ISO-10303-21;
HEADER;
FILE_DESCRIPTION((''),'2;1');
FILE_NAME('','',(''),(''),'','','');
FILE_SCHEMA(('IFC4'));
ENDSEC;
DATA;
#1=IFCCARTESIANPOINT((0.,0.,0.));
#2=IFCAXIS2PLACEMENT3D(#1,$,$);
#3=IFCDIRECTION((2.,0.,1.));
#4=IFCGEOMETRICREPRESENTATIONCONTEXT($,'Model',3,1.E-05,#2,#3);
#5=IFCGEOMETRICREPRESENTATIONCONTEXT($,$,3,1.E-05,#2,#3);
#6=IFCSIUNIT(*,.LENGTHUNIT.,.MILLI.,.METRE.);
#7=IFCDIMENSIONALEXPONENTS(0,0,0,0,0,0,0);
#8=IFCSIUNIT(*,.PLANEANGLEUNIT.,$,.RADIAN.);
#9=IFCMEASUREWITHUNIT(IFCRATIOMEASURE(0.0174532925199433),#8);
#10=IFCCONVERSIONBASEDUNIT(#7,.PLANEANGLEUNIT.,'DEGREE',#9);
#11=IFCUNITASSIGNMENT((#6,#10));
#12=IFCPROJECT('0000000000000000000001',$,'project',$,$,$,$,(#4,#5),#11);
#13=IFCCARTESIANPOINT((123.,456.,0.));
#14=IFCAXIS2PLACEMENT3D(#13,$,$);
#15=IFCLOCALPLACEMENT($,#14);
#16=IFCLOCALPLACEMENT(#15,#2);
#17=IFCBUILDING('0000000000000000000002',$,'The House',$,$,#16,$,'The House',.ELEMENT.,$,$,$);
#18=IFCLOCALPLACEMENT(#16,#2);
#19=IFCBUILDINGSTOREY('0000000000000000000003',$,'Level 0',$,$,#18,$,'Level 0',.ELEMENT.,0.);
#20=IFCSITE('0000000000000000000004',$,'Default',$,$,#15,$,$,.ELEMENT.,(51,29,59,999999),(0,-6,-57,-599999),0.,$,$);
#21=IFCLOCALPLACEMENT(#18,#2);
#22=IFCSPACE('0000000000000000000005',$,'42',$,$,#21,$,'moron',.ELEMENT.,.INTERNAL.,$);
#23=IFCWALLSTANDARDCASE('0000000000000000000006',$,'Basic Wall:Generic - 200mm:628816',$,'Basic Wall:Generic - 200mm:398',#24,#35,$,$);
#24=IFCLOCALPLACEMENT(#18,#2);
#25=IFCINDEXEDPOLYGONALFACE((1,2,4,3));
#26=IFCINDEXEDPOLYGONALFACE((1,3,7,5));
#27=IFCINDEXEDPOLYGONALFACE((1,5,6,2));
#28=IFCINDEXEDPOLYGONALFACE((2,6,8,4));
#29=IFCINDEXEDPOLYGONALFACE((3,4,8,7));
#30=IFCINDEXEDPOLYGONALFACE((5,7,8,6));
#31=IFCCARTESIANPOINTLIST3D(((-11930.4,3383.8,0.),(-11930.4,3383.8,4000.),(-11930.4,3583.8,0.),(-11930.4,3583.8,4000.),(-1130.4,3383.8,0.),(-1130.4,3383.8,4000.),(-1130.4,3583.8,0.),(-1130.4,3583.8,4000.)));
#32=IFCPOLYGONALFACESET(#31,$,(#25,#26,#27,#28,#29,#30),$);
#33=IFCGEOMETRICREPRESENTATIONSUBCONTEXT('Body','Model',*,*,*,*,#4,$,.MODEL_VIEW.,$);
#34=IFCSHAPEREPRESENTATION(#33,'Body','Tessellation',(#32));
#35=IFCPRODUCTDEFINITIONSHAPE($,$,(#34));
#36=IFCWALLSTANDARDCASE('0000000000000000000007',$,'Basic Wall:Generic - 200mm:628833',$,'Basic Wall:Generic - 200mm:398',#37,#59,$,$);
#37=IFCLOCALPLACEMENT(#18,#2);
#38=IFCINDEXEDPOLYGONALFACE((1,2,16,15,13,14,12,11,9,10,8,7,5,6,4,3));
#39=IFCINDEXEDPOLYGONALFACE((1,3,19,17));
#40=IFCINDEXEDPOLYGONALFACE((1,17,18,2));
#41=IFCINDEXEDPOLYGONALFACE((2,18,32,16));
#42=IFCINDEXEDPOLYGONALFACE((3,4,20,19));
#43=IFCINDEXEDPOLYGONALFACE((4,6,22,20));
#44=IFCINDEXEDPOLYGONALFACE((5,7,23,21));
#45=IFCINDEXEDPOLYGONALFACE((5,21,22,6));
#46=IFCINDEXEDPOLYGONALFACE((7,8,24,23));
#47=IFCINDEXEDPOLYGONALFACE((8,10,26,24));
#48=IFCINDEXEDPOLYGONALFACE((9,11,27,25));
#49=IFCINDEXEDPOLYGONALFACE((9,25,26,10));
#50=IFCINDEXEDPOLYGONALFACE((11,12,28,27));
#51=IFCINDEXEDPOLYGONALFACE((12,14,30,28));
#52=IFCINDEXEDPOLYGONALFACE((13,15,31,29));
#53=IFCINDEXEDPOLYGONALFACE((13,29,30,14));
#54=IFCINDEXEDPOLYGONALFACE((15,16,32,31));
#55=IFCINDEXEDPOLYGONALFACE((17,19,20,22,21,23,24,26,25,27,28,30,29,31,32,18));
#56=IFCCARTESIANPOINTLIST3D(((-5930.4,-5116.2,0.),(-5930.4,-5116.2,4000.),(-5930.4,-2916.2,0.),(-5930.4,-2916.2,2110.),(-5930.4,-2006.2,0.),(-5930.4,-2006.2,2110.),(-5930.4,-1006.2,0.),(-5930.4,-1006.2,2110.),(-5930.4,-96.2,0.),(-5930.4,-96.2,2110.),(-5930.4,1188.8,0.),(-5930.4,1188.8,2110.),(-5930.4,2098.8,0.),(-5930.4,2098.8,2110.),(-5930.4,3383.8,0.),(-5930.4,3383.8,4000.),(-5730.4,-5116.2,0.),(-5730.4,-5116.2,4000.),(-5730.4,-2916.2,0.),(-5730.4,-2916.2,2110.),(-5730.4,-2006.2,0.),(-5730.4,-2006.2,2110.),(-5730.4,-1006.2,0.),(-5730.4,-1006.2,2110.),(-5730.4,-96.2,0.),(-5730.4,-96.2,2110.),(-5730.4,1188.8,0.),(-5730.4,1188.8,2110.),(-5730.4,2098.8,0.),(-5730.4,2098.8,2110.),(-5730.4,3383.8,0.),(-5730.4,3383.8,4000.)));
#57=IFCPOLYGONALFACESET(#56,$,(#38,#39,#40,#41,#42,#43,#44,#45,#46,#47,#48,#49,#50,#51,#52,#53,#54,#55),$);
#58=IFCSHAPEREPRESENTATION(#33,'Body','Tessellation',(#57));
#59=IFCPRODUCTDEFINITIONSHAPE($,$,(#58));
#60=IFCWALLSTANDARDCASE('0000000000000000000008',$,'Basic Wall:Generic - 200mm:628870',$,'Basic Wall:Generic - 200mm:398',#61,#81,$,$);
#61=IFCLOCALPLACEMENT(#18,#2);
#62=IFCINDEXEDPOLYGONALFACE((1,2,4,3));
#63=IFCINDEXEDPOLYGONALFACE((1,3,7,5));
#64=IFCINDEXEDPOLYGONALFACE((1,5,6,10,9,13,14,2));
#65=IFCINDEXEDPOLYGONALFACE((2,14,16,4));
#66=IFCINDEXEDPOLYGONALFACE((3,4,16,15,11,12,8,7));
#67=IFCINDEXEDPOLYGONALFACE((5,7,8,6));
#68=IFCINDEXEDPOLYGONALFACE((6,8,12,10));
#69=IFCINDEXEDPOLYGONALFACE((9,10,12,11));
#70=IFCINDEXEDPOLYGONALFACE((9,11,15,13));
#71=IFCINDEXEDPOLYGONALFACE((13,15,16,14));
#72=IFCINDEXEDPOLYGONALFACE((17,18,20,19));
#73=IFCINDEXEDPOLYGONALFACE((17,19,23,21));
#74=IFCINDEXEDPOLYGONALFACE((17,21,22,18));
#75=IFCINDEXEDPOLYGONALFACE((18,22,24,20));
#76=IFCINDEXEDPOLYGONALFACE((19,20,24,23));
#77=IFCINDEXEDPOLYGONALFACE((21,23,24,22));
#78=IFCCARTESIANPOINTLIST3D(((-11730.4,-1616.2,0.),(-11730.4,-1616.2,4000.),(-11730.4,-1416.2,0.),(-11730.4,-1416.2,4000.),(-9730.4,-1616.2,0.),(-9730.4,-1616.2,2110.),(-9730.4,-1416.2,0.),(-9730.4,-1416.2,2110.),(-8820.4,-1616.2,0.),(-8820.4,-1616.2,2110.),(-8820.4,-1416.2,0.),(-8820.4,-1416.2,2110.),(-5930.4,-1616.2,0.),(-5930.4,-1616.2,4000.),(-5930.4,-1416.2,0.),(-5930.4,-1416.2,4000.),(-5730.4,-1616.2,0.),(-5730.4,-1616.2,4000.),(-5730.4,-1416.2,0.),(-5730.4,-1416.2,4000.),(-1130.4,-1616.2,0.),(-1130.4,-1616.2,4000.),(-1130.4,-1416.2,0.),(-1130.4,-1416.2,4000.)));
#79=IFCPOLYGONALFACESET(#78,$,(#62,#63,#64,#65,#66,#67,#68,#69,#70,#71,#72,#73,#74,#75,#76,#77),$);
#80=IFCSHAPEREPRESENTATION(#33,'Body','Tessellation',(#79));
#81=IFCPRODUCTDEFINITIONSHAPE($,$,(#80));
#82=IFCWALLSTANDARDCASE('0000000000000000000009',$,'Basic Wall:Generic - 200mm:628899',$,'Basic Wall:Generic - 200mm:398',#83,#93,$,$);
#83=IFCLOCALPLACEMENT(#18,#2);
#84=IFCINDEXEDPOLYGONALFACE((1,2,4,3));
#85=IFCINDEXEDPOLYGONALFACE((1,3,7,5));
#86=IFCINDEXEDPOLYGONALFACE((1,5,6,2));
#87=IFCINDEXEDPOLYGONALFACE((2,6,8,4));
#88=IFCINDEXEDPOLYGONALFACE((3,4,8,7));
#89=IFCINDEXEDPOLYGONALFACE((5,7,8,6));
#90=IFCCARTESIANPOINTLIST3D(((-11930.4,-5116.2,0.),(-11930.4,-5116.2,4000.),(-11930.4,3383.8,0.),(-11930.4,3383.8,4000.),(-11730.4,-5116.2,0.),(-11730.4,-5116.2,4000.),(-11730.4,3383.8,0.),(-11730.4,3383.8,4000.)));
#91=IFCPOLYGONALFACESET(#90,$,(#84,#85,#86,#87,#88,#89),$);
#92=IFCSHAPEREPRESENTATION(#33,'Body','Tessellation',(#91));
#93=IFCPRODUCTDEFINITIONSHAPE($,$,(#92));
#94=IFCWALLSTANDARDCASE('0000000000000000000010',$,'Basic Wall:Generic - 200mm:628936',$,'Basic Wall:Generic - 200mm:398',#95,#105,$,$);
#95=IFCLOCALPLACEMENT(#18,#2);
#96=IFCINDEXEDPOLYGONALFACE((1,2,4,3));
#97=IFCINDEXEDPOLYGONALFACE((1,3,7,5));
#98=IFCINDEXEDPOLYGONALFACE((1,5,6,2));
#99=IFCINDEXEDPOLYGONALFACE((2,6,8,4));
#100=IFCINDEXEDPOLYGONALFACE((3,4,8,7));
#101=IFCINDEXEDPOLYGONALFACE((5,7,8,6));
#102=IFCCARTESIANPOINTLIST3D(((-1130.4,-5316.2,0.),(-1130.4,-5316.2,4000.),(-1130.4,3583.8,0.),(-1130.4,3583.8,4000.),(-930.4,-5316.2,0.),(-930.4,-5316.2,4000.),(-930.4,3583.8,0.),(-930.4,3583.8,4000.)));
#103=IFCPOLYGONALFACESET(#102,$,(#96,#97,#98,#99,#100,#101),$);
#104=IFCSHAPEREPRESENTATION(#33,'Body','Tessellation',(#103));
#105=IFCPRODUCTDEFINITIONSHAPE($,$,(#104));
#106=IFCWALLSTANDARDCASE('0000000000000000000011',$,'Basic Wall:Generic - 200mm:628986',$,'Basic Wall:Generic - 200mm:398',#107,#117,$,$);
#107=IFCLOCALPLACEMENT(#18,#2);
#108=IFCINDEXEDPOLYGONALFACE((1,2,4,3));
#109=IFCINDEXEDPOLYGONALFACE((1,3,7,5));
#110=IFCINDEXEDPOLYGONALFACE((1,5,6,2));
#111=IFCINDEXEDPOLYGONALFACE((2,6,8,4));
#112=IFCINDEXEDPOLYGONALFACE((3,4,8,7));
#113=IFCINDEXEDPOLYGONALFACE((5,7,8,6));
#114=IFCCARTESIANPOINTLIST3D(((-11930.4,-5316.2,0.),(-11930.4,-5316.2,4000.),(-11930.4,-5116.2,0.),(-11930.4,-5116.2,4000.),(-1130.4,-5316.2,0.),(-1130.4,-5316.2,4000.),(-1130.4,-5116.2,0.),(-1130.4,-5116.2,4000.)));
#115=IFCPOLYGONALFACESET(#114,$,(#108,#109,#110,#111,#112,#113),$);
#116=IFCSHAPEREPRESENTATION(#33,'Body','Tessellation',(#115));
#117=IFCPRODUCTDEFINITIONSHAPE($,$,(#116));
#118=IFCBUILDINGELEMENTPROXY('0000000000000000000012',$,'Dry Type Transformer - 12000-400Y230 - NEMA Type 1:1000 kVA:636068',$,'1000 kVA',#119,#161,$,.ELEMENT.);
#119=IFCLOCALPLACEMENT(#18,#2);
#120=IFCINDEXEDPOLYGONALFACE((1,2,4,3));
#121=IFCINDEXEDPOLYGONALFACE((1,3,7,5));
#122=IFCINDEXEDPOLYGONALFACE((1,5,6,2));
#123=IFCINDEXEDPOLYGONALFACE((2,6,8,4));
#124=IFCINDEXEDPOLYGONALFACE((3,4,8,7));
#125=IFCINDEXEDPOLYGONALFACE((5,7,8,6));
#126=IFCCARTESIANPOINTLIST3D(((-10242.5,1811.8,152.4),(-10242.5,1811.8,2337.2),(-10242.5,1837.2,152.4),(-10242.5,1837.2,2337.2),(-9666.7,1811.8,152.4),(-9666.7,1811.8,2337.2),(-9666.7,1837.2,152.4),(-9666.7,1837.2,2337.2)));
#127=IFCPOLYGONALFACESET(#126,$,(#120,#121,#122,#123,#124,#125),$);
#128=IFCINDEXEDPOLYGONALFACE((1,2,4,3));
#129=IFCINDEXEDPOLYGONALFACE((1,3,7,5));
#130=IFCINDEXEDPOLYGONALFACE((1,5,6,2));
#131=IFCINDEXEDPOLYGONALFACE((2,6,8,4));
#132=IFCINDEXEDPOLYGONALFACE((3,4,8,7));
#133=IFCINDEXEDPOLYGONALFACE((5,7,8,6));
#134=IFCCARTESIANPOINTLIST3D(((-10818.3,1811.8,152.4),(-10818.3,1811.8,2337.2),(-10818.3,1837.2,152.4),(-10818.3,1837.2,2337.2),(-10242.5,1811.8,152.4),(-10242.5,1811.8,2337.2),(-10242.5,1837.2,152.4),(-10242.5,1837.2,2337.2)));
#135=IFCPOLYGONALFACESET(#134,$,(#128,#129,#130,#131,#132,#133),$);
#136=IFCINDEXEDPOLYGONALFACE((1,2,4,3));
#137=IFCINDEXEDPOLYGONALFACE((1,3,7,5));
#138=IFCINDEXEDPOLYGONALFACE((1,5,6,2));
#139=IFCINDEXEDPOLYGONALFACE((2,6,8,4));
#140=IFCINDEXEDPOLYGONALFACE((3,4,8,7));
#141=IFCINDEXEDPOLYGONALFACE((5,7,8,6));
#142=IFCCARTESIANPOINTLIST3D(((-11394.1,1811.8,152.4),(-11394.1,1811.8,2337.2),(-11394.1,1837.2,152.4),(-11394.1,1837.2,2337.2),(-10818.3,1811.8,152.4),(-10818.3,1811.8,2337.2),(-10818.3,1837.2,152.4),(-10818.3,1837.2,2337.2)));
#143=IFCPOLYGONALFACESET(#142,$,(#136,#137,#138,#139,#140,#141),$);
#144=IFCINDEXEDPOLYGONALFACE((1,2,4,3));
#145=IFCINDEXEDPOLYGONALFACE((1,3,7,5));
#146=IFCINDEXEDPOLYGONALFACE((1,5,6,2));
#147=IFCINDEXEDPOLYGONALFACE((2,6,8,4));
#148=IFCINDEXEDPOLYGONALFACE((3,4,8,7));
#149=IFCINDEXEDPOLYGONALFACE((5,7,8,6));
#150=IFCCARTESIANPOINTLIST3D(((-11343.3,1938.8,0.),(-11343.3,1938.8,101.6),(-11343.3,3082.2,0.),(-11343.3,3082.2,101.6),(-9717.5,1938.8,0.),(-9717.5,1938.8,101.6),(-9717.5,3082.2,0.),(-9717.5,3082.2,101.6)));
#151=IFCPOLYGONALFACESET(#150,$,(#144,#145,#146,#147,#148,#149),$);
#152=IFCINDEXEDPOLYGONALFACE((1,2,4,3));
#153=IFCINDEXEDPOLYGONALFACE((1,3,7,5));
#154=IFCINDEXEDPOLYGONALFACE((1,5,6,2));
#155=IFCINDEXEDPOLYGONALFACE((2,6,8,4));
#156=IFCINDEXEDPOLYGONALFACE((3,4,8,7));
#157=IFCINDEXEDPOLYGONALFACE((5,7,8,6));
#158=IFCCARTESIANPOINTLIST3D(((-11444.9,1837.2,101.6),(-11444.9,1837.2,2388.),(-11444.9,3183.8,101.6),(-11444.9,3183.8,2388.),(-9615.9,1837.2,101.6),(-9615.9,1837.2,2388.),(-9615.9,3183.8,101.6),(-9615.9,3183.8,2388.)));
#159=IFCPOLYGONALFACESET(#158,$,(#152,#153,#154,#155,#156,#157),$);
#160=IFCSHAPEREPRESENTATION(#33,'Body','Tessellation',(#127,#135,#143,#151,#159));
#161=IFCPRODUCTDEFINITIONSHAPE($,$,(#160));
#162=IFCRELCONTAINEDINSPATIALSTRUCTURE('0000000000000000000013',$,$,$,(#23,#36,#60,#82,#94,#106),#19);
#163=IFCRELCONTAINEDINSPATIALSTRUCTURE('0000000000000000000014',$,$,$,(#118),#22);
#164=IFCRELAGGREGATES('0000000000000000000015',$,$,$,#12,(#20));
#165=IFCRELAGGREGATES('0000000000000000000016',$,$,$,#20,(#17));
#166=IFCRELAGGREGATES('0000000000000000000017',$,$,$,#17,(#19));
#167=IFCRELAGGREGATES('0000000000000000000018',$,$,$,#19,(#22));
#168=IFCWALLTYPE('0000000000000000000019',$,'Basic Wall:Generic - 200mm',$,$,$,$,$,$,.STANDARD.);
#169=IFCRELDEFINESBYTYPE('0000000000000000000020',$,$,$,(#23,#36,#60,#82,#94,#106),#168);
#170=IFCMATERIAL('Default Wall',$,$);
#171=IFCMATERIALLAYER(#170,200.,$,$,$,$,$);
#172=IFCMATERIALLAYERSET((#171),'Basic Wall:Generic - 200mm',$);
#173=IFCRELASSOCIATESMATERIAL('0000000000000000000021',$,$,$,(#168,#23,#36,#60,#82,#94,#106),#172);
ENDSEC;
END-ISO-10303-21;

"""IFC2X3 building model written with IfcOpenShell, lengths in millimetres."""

from ifc_helpers import new_model, entity, si_unit, converted_unit, direction, frame, frame_2d, origin, origin_2d_with_axis, place, context, subcontext, project, spatial, rectangle, extrude, source, transform, mapped, material, layer, layer_set, layer_usage, type_object, element, save


model = new_model("IFC2X3")

# Units and contexts
model_context = context("Model", 3, precision=1e-05, world=origin(), true_north=direction((2.0, 0.0, 1.0)))
context_of_model = context(None, 3, precision=1e-05, world=origin(), true_north=direction((2.0, 0.0, 1.0)))
body_context = subcontext(model_context, "Body", "Model", "MODEL_VIEW")
ifc_project = project(units=[si_unit("LENGTHUNIT", "METRE", prefix="MILLI"), converted_unit("PLANEANGLEUNIT", "DEGREE", entity("IfcRatioMeasure", 0.0174532925199433), si_unit("PLANEANGLEUNIT", "RADIAN"), dimensions=[0, 0, 0, 0, 0, 0, 0])], contexts=[model_context, context_of_model])

# Site, building, storey
site_placement = place(None, frame((123.0, 456.0, 0.0)))
site = spatial("IfcSite", under=ifc_project, at=site_placement, Name="Default", CompositionType="ELEMENT", RefLatitude=(51, 29, 59, 999999), RefLongitude=(0, -6, -57, -599999), RefElevation=0.0)
building_placement = place(site_placement, origin())
building = spatial("IfcBuilding", under=site, at=building_placement, Name="The House", LongName="The House", CompositionType="ELEMENT")
storey_placement = place(building_placement, origin())
storey = spatial("IfcBuildingStorey", under=building, at=storey_placement, Name="Level 0", LongName="Level 0", CompositionType="ELEMENT", Elevation=0.0)

# Wall
ifc_material = material(Name="Default Wall")
ifc_layer = layer(ifc_material, 200.0)
ifc_layer_set = layer_set([ifc_layer], Name="Basic Wall:Generic - 200mm")
ifc_layer_usage_1 = layer_usage(ifc_layer_set, "AXIS2", "NEGATIVE", 100.0)
wall_type = type_object("IfcWallType", Name="Basic Wall:Generic - 200mm", PredefinedType="STANDARD", material=ifc_layer_set)
wall_1_placement = place(storey_placement, frame((-11930.4, 3483.8, 0.0)))
element("IfcWallStandardCase", 1, at=wall_1_placement, inside=storey, type_object=wall_type, material=ifc_layer_usage_1, Name="Basic Wall:Generic - 200mm:628816", ObjectType="Basic Wall:Generic - 200mm:398", context=body_context, shape_type="SweptSolid", body=[
    extrude(rectangle(XDim=10800.0, YDim=200.0, at=frame_2d((5400.0, 0.0), x_axis=(-1.0, 0.0))), origin(), (0.0, 0.0, 1.0), 4000.0),
])

# Walls, openings
ifc_layer_usage_2 = layer_usage(ifc_layer_set, "AXIS2", "NEGATIVE", 100.0)
wall_2_placement = place(storey_placement, frame((-5830.4, 3383.8, 0.0), z_axis=(0.0, 0.0, 1.0), x_axis=(0.0, -1.0, 0.0)))
wall_2 = element("IfcWallStandardCase", 2, at=wall_2_placement, inside=storey, type_object=wall_type, material=ifc_layer_usage_2, Name="Basic Wall:Generic - 200mm:628833", ObjectType="Basic Wall:Generic - 200mm:398", context=body_context, shape_type="SweptSolid", body=[
    extrude(rectangle(XDim=8500.0, YDim=200.0, at=frame_2d((4250.0, 0.0), x_axis=(-1.0, 0.0))), origin(), (0.0, 0.0, 1.0), 4000.0),
])
opening_1_placement = place(wall_2_placement, frame((6300.0, 100.0, 0.0)))
element("IfcOpeningElement", 3, at=opening_1_placement, cuts=wall_2, ObjectType="Opening", context=body_context, shape_type="SweptSolid", body=[
    extrude(rectangle(XDim=2110.0, YDim=910.0, at=frame_2d((1055.0, 455.0), x_axis=(1.0, 0.0))), frame((0.0, 0.0, 0.0), z_axis=(0.0, -1.0, 0.0), x_axis=(0.0, 0.0, 1.0)), (0.0, 0.0, 1.0), 200.0),
])
opening_2_placement = place(wall_2_placement, frame((3480.0, -100.0, 0.0)))
element("IfcOpeningElement", 4, at=opening_2_placement, cuts=wall_2, ObjectType="Opening", context=body_context, shape_type="SweptSolid", body=[
    extrude(rectangle(XDim=2110.0, YDim=910.0, at=frame_2d((1055.0, 455.0), x_axis=(1.0, 0.0))), frame((0.0, 0.0, 0.0), z_axis=(0.0, 1.0, 0.0), x_axis=(0.0, 0.0, 1.0)), (0.0, 0.0, 1.0), 200.0),
])
opening_3_placement = place(wall_2_placement, frame((2195.0, 100.0, 0.0)))
element("IfcOpeningElement", 5, at=opening_3_placement, cuts=wall_2, ObjectType="Opening", context=body_context, shape_type="SweptSolid", body=[
    extrude(rectangle(XDim=2110.0, YDim=910.0, at=frame_2d((1055.0, 455.0), x_axis=(1.0, 0.0))), frame((0.0, 0.0, 0.0), z_axis=(0.0, -1.0, 0.0), x_axis=(0.0, 0.0, 1.0)), (0.0, 0.0, 1.0), 200.0),
])
ifc_layer_usage_3 = layer_usage(ifc_layer_set, "AXIS2", "NEGATIVE", 100.0)
wall_3_placement = place(storey_placement, frame((-1130.4, -1516.2, 0.0), z_axis=(0.0, 0.0, 1.0), x_axis=(-1.0, 0.0, 0.0)))
wall_3 = element("IfcWallStandardCase", 6, at=wall_3_placement, inside=storey, type_object=wall_type, material=ifc_layer_usage_3, Name="Basic Wall:Generic - 200mm:628870", ObjectType="Basic Wall:Generic - 200mm:398", context=body_context, shape_type="SweptSolid", body=[
    extrude(rectangle(XDim=10600.0, YDim=200.0, at=frame_2d((5300.0, 0.0), x_axis=(-1.0, 0.0))), origin(), (0.0, 0.0, 1.0), 4000.0),
])
opening_4_placement = place(storey_placement, frame((-1130.4, -1516.2, 0.0), z_axis=(0.0, 0.0, 1.0), x_axis=(-1.0, 0.0, 0.0)))
element("IfcOpeningElement", 7, at=opening_4_placement, cuts=wall_3, ObjectType="Opening", context=body_context, shape_type="SweptSolid", body=[
    extrude(rectangle(XDim=4000.0, YDim=200.0, at=origin_2d_with_axis()), frame((4800.0, 0.0, 2000.0), z_axis=(-1.0, 0.0, 0.0), x_axis=(0.0, 0.0, 1.0)), (0.0, 0.0, 1.0), 200.0),
])
opening_5_placement = place(wall_3_placement, frame((8600.0, 100.0, 0.0)))
element("IfcOpeningElement", 8, at=opening_5_placement, cuts=wall_3, ObjectType="Opening", context=body_context, shape_type="SweptSolid", body=[
    extrude(rectangle(XDim=2110.0, YDim=910.0, at=frame_2d((1055.0, 455.0), x_axis=(1.0, 0.0))), frame((0.0, 0.0, 0.0), z_axis=(0.0, -1.0, 0.0), x_axis=(0.0, 0.0, 1.0)), (0.0, 0.0, 1.0), 200.0),
])

# Walls
ifc_layer_usage_4 = layer_usage(ifc_layer_set, "AXIS2", "NEGATIVE", 100.0)
wall_4_placement = place(storey_placement, frame((-11830.4, -5116.2, 0.0), z_axis=(0.0, 0.0, 1.0), x_axis=(0.0, 1.0, 0.0)))
element("IfcWallStandardCase", 9, at=wall_4_placement, inside=storey, type_object=wall_type, material=ifc_layer_usage_4, Name="Basic Wall:Generic - 200mm:628899", ObjectType="Basic Wall:Generic - 200mm:398", context=body_context, shape_type="SweptSolid", body=[
    extrude(rectangle(XDim=8500.0, YDim=200.0, at=frame_2d((4250.0, 0.0), x_axis=(-1.0, 0.0))), origin(), (0.0, 0.0, 1.0), 4000.0),
])
ifc_layer_usage_5 = layer_usage(ifc_layer_set, "AXIS2", "NEGATIVE", 100.0)
wall_5_placement = place(storey_placement, frame((-1030.4, 3583.8, 0.0), z_axis=(0.0, 0.0, 1.0), x_axis=(0.0, -1.0, 0.0)))
element("IfcWallStandardCase", 10, at=wall_5_placement, inside=storey, type_object=wall_type, material=ifc_layer_usage_5, Name="Basic Wall:Generic - 200mm:628936", ObjectType="Basic Wall:Generic - 200mm:398", context=body_context, shape_type="SweptSolid", body=[
    extrude(rectangle(XDim=8900.0, YDim=200.0, at=frame_2d((4450.0, 0.0), x_axis=(-1.0, 0.0))), origin(), (0.0, 0.0, 1.0), 4000.0),
])
ifc_layer_usage_6 = layer_usage(ifc_layer_set, "AXIS2", "NEGATIVE", 100.0)
wall_6_placement = place(storey_placement, frame((-1130.4, -5216.2, 0.0), z_axis=(0.0, 0.0, 1.0), x_axis=(-1.0, 0.0, 0.0)))
element("IfcWallStandardCase", 11, at=wall_6_placement, inside=storey, type_object=wall_type, material=ifc_layer_usage_6, Name="Basic Wall:Generic - 200mm:628986", ObjectType="Basic Wall:Generic - 200mm:398", context=body_context, shape_type="SweptSolid", body=[
    extrude(rectangle(XDim=10800.0, YDim=200.0, at=frame_2d((5400.0, 0.0), x_axis=(-1.0, 0.0))), origin(), (0.0, 0.0, 1.0), 4000.0),
])

# Shared definitions
space_1_placement = place(storey_placement, origin())
space_1 = spatial("IfcSpace", under=storey, at=space_1_placement, Name="42", LongName="moron", CompositionType="ELEMENT", InteriorOrExteriorSpace="INTERNAL")

# Building element proxy
shared_shape = source(origin(), body_context, "Body", "SweptSolid", [
    extrude(rectangle(XDim=575.8, YDim=25.4, at=frame_2d((0.0, 0.0), x_axis=(1.0, 0.0))), frame((575.8, -1359.3, 152.4), z_axis=(0.0, 0.0, 1.0), x_axis=(-1.0, 0.0, 0.0)), (0.0, 0.0, 1.0), 2184.8),
    extrude(rectangle(XDim=575.8, YDim=25.4, at=origin_2d_with_axis()), frame((0.0, -1359.3, 152.4), z_axis=(0.0, 0.0, 1.0), x_axis=(-1.0, 0.0, 0.0)), (0.0, 0.0, 1.0), 2184.8),
    extrude(rectangle(XDim=575.8, YDim=25.4, at=origin_2d_with_axis()), frame((-575.8, -1359.3, 152.4), z_axis=(0.0, 0.0, 1.0), x_axis=(-1.0, 0.0, 0.0)), (0.0, 0.0, 1.0), 2184.8),
    extrude(rectangle(XDim=1625.8, YDim=1143.4, at=frame_2d((0.0, 0.0), x_axis=(1.0, 0.0))), frame((0.0, -673.3, 0.0), z_axis=(0.0, 0.0, 1.0), x_axis=(-1.0, 0.0, 0.0)), (0.0, 0.0, 1.0), 101.6),
    extrude(rectangle(XDim=1829.0, YDim=1346.6, at=origin_2d_with_axis()), frame((0.0, -673.3, 101.6), z_axis=(0.0, 0.0, 1.0), x_axis=(-1.0, 0.0, 0.0)), (0.0, 0.0, 1.0), 2286.4),
])
proxy_1_placement = place(space_1_placement, frame((-10530.4, 3183.8, 0.0)))
element("IfcBuildingElementProxy", 12, at=proxy_1_placement, inside=space_1, Name="Dry Type Transformer - 12000-400Y230 - NEMA Type 1:1000 kVA:636068", ObjectType="1000 kVA", CompositionType="ELEMENT", context=body_context, shape_type="MappedRepresentation", body=[
    mapped(shared_shape, transform((0.0, 0.0, 0.0), scale=1.0)),
])

save(model, "model.ifc")
